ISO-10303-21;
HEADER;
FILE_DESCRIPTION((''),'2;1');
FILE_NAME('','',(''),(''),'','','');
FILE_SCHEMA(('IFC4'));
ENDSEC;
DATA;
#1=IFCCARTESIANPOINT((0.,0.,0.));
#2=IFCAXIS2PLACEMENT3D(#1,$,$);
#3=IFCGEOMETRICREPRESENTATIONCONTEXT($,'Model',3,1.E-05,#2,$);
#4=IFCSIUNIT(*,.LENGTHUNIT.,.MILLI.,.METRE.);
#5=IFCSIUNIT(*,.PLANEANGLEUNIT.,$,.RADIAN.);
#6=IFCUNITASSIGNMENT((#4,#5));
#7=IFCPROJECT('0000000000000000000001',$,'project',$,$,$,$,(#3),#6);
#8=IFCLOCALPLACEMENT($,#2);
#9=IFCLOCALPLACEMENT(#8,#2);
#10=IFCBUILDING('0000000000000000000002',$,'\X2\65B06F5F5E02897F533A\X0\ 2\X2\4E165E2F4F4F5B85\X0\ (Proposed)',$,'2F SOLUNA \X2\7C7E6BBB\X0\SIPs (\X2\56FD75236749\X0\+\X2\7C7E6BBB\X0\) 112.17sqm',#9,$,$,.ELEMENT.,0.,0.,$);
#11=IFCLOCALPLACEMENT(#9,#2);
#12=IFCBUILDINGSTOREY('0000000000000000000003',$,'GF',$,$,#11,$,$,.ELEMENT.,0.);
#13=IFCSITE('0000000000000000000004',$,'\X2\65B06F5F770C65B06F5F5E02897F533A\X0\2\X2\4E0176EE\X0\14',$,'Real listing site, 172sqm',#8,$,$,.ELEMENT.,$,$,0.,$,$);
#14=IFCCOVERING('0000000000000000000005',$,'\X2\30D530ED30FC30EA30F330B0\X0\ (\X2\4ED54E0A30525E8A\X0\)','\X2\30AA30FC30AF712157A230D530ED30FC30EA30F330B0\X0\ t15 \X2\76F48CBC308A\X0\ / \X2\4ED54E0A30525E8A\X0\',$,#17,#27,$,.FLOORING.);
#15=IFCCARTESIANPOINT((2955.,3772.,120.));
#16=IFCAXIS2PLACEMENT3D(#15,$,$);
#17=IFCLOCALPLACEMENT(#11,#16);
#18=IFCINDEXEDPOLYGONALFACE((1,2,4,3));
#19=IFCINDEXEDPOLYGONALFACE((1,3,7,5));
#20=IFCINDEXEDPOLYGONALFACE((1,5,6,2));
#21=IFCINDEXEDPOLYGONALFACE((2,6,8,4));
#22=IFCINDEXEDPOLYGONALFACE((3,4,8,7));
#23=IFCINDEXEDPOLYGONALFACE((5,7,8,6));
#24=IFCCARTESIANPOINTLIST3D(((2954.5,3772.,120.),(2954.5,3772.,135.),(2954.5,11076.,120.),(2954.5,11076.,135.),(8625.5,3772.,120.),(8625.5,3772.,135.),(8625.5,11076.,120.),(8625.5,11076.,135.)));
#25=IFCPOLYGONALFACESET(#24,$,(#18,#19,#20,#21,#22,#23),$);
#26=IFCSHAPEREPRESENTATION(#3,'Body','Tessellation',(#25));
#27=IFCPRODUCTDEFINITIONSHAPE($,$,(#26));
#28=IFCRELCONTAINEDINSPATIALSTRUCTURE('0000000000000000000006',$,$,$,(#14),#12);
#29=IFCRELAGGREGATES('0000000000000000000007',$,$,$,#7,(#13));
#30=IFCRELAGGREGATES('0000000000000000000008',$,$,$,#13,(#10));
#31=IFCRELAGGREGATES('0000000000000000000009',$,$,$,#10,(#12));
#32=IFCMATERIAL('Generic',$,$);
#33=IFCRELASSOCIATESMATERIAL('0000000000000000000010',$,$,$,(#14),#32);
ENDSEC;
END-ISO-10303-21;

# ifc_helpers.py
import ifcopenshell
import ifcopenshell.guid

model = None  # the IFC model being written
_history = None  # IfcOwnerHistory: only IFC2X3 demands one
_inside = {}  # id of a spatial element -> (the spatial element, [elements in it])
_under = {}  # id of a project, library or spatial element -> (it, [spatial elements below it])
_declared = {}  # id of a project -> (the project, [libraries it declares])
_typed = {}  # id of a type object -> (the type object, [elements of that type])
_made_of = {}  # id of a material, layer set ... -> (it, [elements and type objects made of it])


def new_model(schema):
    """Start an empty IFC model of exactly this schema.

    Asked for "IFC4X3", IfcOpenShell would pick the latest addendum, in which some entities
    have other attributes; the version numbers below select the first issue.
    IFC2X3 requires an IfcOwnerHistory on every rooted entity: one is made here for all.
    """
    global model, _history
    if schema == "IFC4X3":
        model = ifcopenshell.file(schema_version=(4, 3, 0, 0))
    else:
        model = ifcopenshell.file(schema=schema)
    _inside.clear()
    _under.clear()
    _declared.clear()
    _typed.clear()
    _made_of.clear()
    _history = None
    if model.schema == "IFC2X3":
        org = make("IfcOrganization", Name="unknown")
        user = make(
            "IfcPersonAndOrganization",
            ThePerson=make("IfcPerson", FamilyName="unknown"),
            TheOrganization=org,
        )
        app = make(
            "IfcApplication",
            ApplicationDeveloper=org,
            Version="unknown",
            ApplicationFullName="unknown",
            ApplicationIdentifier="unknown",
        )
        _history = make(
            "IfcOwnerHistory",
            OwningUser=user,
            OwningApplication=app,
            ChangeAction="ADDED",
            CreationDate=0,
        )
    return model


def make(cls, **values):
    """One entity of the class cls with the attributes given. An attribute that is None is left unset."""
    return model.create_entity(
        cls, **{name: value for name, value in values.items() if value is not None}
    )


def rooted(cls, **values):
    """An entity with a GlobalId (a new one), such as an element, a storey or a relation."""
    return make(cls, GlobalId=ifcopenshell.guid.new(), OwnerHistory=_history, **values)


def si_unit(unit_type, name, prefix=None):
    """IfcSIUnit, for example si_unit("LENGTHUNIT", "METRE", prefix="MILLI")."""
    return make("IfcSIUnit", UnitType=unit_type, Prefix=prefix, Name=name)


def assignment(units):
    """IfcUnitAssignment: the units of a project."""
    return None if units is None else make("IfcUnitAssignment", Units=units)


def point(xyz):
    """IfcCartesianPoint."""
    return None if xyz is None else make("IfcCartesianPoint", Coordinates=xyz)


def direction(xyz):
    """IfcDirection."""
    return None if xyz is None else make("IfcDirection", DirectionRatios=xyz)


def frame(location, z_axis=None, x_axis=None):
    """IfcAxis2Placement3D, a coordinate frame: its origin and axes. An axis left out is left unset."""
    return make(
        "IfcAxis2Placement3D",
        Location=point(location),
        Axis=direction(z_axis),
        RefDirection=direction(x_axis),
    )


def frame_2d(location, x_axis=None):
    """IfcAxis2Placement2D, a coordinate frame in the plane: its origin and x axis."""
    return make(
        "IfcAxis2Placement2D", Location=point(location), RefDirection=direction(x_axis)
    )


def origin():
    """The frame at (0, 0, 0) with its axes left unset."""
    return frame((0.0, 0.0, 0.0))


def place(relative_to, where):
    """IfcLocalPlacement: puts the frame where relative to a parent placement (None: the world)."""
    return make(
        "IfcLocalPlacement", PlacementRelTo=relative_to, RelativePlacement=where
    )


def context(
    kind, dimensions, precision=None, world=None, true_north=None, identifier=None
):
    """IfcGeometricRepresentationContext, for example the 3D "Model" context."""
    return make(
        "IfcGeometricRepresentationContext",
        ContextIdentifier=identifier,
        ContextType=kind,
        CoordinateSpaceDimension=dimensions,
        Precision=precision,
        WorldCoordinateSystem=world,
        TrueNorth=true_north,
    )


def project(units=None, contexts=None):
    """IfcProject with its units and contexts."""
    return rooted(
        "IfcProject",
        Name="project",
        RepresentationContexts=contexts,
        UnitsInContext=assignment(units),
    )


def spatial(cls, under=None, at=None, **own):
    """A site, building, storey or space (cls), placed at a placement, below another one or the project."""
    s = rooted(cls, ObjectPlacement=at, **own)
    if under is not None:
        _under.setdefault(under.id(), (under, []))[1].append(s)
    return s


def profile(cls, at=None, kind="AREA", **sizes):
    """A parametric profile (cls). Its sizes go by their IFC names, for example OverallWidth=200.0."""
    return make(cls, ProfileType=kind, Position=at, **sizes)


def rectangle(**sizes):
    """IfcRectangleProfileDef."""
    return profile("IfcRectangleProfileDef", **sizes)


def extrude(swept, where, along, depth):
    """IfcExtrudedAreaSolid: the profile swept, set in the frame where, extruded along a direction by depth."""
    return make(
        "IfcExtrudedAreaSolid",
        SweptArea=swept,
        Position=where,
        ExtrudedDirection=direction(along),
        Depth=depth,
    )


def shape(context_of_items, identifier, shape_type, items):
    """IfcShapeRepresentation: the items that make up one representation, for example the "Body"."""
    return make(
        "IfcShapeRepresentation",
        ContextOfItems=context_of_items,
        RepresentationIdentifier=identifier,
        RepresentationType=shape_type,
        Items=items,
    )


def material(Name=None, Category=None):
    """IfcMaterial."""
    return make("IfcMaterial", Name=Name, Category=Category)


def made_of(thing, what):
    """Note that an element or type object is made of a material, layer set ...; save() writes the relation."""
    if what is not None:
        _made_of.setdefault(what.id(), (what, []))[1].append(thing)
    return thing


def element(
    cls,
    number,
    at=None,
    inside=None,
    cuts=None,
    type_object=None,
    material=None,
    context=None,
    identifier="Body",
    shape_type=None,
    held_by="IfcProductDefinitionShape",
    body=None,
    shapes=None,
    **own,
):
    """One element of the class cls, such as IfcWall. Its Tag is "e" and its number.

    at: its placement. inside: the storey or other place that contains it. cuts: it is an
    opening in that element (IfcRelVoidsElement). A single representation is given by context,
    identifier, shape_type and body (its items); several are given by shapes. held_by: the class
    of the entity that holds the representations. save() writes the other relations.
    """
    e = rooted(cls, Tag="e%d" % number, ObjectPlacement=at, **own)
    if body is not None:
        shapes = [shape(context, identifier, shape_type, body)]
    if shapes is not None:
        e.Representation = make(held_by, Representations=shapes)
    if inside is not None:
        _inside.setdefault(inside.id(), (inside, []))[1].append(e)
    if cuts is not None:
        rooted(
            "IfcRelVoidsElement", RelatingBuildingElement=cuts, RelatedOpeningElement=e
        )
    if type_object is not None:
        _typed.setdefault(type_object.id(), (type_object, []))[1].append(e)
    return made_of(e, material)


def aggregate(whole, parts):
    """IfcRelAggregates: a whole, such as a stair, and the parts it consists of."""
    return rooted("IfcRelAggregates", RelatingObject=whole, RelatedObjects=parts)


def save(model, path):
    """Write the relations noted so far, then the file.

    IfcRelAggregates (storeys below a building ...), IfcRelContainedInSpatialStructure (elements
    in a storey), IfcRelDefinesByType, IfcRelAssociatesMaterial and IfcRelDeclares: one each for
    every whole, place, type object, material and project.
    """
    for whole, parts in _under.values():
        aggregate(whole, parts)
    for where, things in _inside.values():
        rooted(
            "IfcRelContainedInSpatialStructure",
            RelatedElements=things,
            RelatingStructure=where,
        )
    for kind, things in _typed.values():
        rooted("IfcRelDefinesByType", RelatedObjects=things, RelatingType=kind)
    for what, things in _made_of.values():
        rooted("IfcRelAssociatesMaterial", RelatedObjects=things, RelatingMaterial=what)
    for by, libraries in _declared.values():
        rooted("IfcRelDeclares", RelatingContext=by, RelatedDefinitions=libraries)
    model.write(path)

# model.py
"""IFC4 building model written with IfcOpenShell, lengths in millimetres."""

from ifc_helpers import new_model, si_unit, frame, frame_2d, origin, place, context, project, spatial, rectangle, extrude, material, element, save


model = new_model("IFC4")

# Units and contexts
model_context = context("Model", 3, precision=1e-05, world=origin())
ifc_project = project(units=[si_unit("LENGTHUNIT", "METRE", prefix="MILLI"), si_unit("PLANEANGLEUNIT", "RADIAN")], contexts=[model_context])

# Site, building, storey
site_placement = place(None, origin())
site = spatial("IfcSite", under=ifc_project, at=site_placement, Name="新潟県新潟市西区2丁目14", ObjectType="Real listing site, 172sqm", CompositionType="ELEMENT", RefElevation=0.0)
building_placement = place(site_placement, origin())
building = spatial("IfcBuilding", under=site, at=building_placement, Name="新潟市西区 2世帯住宅 (Proposed)", ObjectType="2F SOLUNA 籾殻SIPs (国産杉+籾殻) 112.17sqm", CompositionType="ELEMENT", ElevationOfRefHeight=0.0, ElevationOfTerrain=0.0)
storey_placement = place(building_placement, origin())
storey = spatial("IfcBuildingStorey", under=building, at=storey_placement, Name="GF", CompositionType="ELEMENT", Elevation=0.0)

# Shared definitions
ifc_material_1 = material(Name="Generic")

# Covering
covering_placement = place(storey_placement, frame((2955.0, 3772.0, 120.0)))
element("IfcCovering", 1, at=covering_placement, inside=storey, material=ifc_material_1, Name="フローリング (仕上げ床)", Description="オーク無垢フローリング t15 直貼り / 仕上げ床", PredefinedType="FLOORING", context=model_context, shape_type="SweptSolid", body=[
    extrude(rectangle(XDim=5671.0, YDim=7304.0, at=frame_2d((2835.0, 3652.0))), frame((2955.0, 3772.0, 120.0)), (0.0, 0.0, 1.0), 15.0),
])

save(model, "model.ifc")
